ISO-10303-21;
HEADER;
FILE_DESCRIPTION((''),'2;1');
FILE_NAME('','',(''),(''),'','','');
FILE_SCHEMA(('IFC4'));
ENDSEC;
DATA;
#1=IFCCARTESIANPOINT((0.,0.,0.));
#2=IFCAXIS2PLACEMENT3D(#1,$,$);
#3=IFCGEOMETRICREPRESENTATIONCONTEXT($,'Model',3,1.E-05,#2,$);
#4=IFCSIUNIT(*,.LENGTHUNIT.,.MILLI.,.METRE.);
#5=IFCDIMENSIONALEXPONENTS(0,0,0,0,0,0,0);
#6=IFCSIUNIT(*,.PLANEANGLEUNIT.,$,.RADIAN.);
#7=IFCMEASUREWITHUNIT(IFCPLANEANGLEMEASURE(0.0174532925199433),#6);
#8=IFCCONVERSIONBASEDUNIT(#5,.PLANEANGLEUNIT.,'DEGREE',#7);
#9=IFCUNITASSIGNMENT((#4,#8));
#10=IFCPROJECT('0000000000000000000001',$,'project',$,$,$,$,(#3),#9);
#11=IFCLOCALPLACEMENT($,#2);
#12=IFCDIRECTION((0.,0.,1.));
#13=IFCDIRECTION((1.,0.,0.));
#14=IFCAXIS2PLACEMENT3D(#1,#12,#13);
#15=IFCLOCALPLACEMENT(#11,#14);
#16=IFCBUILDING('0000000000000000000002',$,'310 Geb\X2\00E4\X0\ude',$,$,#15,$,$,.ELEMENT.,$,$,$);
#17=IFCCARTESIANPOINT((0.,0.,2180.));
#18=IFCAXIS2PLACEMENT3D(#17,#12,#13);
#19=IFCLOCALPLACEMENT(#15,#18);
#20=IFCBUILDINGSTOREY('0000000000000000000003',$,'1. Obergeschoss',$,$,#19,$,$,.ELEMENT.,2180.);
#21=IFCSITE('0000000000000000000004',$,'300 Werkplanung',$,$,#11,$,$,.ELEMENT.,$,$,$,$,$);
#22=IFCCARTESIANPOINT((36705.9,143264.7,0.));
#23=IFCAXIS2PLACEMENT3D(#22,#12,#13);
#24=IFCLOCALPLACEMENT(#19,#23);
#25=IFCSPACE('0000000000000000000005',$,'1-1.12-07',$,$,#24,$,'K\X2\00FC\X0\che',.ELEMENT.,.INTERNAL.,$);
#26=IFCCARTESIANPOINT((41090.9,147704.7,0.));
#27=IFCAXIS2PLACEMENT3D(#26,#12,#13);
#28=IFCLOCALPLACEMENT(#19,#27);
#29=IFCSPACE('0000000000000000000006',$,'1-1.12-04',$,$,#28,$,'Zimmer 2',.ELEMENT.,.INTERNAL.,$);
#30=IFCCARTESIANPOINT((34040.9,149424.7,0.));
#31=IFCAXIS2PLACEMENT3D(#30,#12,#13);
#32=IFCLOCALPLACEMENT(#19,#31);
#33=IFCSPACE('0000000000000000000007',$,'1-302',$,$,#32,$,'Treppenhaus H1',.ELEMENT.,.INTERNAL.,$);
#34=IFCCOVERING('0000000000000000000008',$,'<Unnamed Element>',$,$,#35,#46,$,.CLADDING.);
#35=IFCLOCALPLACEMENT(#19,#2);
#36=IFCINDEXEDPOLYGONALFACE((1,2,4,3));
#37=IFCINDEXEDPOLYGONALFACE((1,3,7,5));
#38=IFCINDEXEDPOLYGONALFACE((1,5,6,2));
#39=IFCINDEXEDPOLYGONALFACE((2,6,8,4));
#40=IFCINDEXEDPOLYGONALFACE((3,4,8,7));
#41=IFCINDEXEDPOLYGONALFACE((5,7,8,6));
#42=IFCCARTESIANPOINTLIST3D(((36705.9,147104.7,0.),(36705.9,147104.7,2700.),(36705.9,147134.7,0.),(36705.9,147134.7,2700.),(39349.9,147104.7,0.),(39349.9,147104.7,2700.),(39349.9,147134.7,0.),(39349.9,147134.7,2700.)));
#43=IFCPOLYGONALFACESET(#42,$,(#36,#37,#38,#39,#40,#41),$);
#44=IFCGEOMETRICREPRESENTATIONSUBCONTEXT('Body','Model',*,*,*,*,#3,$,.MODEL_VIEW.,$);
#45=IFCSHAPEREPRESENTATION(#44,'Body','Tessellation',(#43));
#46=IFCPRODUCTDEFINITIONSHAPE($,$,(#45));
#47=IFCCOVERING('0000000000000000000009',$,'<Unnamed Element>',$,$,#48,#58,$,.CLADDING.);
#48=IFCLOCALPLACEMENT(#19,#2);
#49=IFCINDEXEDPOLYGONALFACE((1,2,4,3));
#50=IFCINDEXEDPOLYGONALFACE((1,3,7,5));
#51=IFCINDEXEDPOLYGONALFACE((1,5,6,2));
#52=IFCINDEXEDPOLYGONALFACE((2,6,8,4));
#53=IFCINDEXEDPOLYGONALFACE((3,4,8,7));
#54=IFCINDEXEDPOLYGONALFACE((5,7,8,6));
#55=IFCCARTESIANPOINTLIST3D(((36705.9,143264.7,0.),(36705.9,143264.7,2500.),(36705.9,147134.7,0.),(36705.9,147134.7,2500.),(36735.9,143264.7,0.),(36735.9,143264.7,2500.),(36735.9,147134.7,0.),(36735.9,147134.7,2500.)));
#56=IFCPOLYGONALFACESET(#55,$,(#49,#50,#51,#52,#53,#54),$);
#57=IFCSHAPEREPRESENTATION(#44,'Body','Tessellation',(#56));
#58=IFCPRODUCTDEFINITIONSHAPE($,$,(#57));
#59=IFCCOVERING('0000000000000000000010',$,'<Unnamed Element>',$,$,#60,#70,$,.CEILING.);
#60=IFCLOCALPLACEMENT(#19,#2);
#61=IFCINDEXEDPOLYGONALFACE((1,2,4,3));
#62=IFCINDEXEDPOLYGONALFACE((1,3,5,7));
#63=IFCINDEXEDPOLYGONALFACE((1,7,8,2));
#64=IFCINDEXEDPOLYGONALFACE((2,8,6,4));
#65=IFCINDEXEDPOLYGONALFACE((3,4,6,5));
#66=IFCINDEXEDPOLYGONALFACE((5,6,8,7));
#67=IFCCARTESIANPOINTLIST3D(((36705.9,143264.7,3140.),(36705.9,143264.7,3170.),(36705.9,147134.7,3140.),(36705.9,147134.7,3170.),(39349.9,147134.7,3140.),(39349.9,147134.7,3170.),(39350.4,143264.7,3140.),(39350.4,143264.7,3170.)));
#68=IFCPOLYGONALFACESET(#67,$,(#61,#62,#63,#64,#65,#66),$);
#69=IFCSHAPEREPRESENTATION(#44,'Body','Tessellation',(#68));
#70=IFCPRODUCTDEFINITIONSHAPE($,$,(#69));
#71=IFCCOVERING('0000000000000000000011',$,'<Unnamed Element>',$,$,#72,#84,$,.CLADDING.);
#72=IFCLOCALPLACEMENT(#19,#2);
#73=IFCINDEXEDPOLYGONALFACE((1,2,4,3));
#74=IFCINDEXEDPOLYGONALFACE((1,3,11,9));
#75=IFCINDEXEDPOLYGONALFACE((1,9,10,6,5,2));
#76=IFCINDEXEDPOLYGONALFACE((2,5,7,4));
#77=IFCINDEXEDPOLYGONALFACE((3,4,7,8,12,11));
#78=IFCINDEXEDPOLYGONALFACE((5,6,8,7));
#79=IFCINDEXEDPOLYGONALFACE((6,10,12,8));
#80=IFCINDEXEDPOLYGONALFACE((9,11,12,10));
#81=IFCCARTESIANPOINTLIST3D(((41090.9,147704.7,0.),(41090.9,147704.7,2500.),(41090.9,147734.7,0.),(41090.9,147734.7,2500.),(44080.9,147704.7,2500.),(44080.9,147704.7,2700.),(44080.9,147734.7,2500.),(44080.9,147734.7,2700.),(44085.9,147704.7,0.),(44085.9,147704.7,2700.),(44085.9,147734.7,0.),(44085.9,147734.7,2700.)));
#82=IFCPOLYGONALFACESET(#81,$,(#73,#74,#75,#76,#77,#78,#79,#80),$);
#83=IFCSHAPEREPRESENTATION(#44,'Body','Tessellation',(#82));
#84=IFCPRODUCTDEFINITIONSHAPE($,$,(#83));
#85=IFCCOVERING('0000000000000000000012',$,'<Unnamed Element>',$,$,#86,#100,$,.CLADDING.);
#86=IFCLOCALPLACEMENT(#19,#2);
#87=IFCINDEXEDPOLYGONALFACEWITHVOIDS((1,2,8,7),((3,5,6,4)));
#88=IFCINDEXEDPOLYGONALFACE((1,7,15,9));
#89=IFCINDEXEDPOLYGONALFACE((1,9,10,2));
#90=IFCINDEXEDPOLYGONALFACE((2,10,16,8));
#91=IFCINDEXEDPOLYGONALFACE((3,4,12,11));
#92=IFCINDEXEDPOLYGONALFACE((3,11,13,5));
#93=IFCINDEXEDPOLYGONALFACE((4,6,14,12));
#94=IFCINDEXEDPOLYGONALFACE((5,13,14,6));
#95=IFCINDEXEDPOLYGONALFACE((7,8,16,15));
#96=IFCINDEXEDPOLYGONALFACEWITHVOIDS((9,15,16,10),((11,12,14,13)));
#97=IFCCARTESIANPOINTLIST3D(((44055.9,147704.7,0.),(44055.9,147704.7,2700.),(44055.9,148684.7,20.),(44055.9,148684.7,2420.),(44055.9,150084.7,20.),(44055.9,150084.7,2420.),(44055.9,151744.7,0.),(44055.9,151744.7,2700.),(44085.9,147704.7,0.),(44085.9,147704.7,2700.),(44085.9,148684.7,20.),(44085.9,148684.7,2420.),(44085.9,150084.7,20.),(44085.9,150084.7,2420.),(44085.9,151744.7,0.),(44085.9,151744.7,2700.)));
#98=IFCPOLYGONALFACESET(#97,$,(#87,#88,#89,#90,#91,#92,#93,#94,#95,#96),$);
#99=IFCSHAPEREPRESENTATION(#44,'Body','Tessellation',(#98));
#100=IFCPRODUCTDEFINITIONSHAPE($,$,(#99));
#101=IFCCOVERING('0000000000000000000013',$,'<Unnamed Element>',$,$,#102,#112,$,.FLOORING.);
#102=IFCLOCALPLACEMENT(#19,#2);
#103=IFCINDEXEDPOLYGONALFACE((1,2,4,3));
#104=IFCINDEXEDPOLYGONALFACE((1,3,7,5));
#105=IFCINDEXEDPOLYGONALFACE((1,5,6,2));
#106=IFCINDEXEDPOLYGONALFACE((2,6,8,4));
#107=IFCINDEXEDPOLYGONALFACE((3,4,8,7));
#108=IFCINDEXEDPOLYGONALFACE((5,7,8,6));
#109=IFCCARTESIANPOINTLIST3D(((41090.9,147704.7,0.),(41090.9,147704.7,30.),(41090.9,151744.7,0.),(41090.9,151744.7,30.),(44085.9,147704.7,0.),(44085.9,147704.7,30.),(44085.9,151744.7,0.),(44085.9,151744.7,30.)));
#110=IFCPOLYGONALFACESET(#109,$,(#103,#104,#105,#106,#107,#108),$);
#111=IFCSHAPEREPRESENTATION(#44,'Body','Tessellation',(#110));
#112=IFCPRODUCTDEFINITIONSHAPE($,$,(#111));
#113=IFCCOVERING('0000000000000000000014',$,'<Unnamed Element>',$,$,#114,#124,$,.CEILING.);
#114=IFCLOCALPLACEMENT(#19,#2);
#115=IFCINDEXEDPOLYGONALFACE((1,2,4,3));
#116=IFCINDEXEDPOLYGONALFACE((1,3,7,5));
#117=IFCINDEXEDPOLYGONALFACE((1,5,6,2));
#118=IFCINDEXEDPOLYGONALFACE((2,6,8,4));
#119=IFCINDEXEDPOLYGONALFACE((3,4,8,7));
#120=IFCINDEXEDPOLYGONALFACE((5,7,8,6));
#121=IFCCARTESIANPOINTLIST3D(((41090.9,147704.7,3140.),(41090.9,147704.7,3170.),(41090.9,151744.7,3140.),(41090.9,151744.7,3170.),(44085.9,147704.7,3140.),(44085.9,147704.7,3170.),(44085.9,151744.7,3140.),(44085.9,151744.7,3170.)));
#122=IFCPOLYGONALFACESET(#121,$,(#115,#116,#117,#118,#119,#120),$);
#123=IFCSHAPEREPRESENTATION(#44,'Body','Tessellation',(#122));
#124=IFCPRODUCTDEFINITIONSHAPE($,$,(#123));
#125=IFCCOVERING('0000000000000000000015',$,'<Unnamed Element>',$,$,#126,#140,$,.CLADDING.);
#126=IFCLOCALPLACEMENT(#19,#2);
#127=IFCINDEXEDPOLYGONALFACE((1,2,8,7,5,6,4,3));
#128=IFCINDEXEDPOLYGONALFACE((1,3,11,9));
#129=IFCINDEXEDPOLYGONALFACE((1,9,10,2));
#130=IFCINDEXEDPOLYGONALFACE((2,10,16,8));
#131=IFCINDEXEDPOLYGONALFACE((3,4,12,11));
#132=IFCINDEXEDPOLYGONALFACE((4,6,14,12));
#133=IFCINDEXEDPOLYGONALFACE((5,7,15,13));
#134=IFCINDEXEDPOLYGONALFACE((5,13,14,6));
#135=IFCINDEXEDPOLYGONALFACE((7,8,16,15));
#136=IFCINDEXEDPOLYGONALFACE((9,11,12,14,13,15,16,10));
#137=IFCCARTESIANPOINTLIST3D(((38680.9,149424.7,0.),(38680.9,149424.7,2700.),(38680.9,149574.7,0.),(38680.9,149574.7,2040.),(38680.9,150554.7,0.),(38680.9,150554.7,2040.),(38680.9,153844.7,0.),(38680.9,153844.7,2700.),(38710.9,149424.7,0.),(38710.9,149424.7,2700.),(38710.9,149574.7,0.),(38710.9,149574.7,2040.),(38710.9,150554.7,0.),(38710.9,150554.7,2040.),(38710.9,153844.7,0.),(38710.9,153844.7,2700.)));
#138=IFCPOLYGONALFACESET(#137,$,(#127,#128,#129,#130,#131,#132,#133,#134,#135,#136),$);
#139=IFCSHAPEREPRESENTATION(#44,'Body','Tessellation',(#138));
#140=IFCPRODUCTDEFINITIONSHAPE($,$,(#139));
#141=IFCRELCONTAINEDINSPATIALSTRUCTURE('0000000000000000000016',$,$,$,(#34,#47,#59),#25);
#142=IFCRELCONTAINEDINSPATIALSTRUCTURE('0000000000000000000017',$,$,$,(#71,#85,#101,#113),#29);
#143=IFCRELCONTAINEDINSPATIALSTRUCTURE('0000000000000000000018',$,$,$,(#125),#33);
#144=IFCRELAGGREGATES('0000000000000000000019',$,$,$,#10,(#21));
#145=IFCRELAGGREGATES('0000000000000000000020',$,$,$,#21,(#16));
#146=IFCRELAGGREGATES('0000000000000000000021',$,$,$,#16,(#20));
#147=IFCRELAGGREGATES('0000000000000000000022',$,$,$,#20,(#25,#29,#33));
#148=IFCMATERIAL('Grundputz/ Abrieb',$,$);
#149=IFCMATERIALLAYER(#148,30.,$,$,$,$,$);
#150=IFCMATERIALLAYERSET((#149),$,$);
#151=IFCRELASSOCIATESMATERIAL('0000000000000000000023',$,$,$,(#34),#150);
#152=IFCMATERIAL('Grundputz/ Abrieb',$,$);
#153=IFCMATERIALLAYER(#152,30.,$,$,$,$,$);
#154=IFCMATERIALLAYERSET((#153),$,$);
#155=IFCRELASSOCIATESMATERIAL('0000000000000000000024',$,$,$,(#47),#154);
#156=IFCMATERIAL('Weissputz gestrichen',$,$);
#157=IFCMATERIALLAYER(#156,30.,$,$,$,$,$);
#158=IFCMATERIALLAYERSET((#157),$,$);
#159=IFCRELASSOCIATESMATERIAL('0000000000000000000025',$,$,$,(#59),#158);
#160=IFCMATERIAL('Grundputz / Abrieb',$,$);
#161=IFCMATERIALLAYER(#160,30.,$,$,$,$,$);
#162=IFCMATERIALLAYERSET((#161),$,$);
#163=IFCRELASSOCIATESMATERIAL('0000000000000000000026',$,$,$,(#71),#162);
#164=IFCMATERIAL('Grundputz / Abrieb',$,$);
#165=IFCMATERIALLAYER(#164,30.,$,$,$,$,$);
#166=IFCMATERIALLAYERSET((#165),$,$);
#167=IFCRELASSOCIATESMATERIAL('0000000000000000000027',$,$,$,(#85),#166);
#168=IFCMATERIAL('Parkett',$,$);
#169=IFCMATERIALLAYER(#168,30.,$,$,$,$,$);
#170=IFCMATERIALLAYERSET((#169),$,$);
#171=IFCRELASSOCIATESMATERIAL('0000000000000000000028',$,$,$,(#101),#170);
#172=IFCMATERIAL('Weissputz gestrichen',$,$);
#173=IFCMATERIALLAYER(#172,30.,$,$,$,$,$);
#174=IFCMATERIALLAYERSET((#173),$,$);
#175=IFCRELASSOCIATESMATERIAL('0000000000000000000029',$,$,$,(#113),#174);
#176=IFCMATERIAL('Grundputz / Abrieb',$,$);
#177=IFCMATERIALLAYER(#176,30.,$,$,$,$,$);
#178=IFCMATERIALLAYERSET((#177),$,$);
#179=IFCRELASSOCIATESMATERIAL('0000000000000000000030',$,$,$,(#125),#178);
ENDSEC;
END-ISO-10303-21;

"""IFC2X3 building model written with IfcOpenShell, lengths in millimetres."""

from ifc_helpers import new_model, entity, si_unit, converted_unit, frame, frame_2d, origin, origin_with_axes, place, context, subcontext, project, spatial, polyline, rectangle, outline, extrude, material, layer, layer_set, layer_usage, element, save


model = new_model("IFC2X3")

# Units and contexts
model_context = context("Model", 3, precision=1e-05, world=origin())
body_context = subcontext(model_context, "Body", "Model", "MODEL_VIEW")
ifc_project = project(units=[si_unit("LENGTHUNIT", "METRE", prefix="MILLI"), converted_unit("PLANEANGLEUNIT", "DEGREE", entity("IfcPlaneAngleMeasure", 0.0174532925199433), si_unit("PLANEANGLEUNIT", "RADIAN"), dimensions=[0, 0, 0, 0, 0, 0, 0])], contexts=[model_context])

# Site, building, storey
site_placement = place(None, origin())
site = spatial("IfcSite", under=ifc_project, at=site_placement, Name="300 Werkplanung", CompositionType="ELEMENT")
building_placement = place(site_placement, origin_with_axes())
building = spatial("IfcBuilding", under=site, at=building_placement, Name="310 Gebäude", CompositionType="ELEMENT")
storey_placement = place(building_placement, frame((0.0, 0.0, 2180.0), z_axis=(0.0, 0.0, 1.0), x_axis=(1.0, 0.0, 0.0)))
storey = spatial("IfcBuildingStorey", under=building, at=storey_placement, Name="1. Obergeschoss", CompositionType="ELEMENT", Elevation=2180.0)

# Shared definitions
space_1_placement = place(storey_placement, frame((36705.9, 143264.7, 0.0), z_axis=(0.0, 0.0, 1.0), x_axis=(1.0, 0.0, 0.0)))
space_1 = spatial("IfcSpace", under=storey, at=space_1_placement, Name="1-1.12-07", LongName="Küche", CompositionType="ELEMENT", InteriorOrExteriorSpace="INTERNAL")

# Coverings
ifc_material_1 = material(Name="Grundputz/ Abrieb")
ifc_layer_1 = layer(ifc_material_1, 30.0)
ifc_layer_set_1 = layer_set([ifc_layer_1])
ifc_layer_usage_1 = layer_usage(ifc_layer_set_1, "AXIS3", "POSITIVE", 0.0)
covering_1_placement = place(space_1_placement, frame((2644.0, 3870.0, 0.0), z_axis=(0.0, 0.0, 1.0), x_axis=(-1.0, 0.0, 0.0)))
element("IfcCovering", 1, at=covering_1_placement, inside=space_1, material=ifc_layer_usage_1, Name="<Unnamed Element>", PredefinedType="CLADDING", context=body_context, shape_type="SweptSolid", body=[
    extrude(rectangle(XDim=2700.0, YDim=2644.0, at=frame_2d((-1322.0, 1350.0), x_axis=(0.0, 1.0))), frame((2644.0, 0.0, 2700.0), z_axis=(0.0, 1.0, 0.0), x_axis=(1.0, 0.0, 0.0)), (0.0, 0.0, 1.0), 30.0),
])
ifc_material_2 = material(Name="Grundputz/ Abrieb")
ifc_layer_2 = layer(ifc_material_2, 30.0)
ifc_layer_set_2 = layer_set([ifc_layer_2])
ifc_layer_usage_2 = layer_usage(ifc_layer_set_2, "AXIS3", "POSITIVE", 0.0)
covering_2_placement = place(space_1_placement, frame((0.0, 3870.0, 0.0), z_axis=(0.0, 0.0, 1.0), x_axis=(0.0, -1.0, 0.0)))
element("IfcCovering", 2, at=covering_2_placement, inside=space_1, material=ifc_layer_usage_2, Name="<Unnamed Element>", PredefinedType="CLADDING", context=body_context, shape_type="SweptSolid", body=[
    extrude(rectangle(XDim=2500.0, YDim=3870.0, at=frame_2d((-1935.0, 1250.0), x_axis=(0.0, 1.0))), frame((3870.0, 0.0, 2500.0), z_axis=(0.0, 1.0, 0.0), x_axis=(1.0, 0.0, 0.0)), (0.0, 0.0, 1.0), 30.0),
])
ifc_material_3 = material(Name="Weissputz gestrichen")
ifc_layer_3 = layer(ifc_material_3, 30.0)
ifc_layer_set_3 = layer_set([ifc_layer_3])
ifc_layer_usage_3 = layer_usage(ifc_layer_set_3, "AXIS3", "POSITIVE", 0.0)
covering_3_placement = place(space_1_placement, frame((1322.1, 1935.0, 3170.0), z_axis=(0.0, 0.0, -1.0), x_axis=(1.0, 0.0, 0.0)))
element("IfcCovering", 3, at=covering_3_placement, inside=space_1, material=ifc_layer_usage_3, Name="<Unnamed Element>", PredefinedType="CEILING", context=body_context, shape_type="SweptSolid", body=[
    extrude(outline(polyline([(-1322.1, -1935.0), (1321.9, -1935.0), (1322.4, 1935.0), (-1322.1, 1935.0), (-1322.1, -1935.0)])), origin_with_axes(), (0.0, 0.0, 1.0), 30.0),
])

# Shared definitions
space_2_placement = place(storey_placement, frame((41090.9, 147704.7, 0.0), z_axis=(0.0, 0.0, 1.0), x_axis=(1.0, 0.0, 0.0)))
space_2 = spatial("IfcSpace", under=storey, at=space_2_placement, Name="1-1.12-04", LongName="Zimmer 2", CompositionType="ELEMENT", InteriorOrExteriorSpace="INTERNAL")

# Coverings
ifc_material_4 = material(Name="Grundputz / Abrieb")
ifc_layer_4 = layer(ifc_material_4, 30.0)
ifc_layer_set_4 = layer_set([ifc_layer_4])
ifc_layer_usage_4 = layer_usage(ifc_layer_set_4, "AXIS3", "POSITIVE", 0.0)
covering_4_placement = place(space_2_placement, frame((0.0, 0.0, 0.0), z_axis=(0.0, 0.0, 1.0), x_axis=(1.0, 0.0, 0.0)))
element("IfcCovering", 4, at=covering_4_placement, inside=space_2, material=ifc_layer_usage_4, Name="<Unnamed Element>", PredefinedType="CLADDING", context=body_context, shape_type="SweptSolid", body=[
    extrude(outline(polyline([(2995.0, 0.0), (2995.0, -2700.0), (2990.0, -2700.0), (2990.0, -2500.0), (0.0, -2500.0), (0.0, 0.0), (2995.0, 0.0)])), frame((0.0, 0.0, 0.0), z_axis=(0.0, 1.0, 0.0), x_axis=(1.0, 0.0, 0.0)), (0.0, 0.0, 1.0), 30.0),
])
ifc_material_5 = material(Name="Grundputz / Abrieb")
ifc_layer_5 = layer(ifc_material_5, 30.0)
ifc_layer_set_5 = layer_set([ifc_layer_5])
ifc_layer_usage_5 = layer_usage(ifc_layer_set_5, "AXIS3", "POSITIVE", 0.0)
covering_5_placement = place(space_2_placement, frame((2995.0, 0.0, 0.0), z_axis=(0.0, 0.0, 1.0), x_axis=(0.0, 1.0, 0.0)))
element("IfcCovering", 5, at=covering_5_placement, inside=space_2, material=ifc_layer_usage_5, Name="<Unnamed Element>", PredefinedType="CLADDING", context=body_context, shape_type="SweptSolid", body=[
    extrude(outline(polyline([(4040.0, 0.0), (4040.0, -2700.0), (0.0, -2700.0), (0.0, 0.0), (4040.0, 0.0)]), holes=[polyline([(2380.0, -20.0), (980.0, -20.0), (980.0, -2420.0), (2380.0, -2420.0), (2380.0, -20.0)])]), frame((0.0, 0.0, 0.0), z_axis=(0.0, 1.0, 0.0), x_axis=(1.0, 0.0, 0.0)), (0.0, 0.0, 1.0), 30.0),
])
ifc_material_6 = material(Name="Parkett")
ifc_layer_6 = layer(ifc_material_6, 30.0)
ifc_layer_set_6 = layer_set([ifc_layer_6])
ifc_layer_usage_6 = layer_usage(ifc_layer_set_6, "AXIS3", "POSITIVE", 0.0)
covering_6_placement = place(space_2_placement, origin_with_axes())
element("IfcCovering", 6, at=covering_6_placement, inside=space_2, material=ifc_layer_usage_6, Name="<Unnamed Element>", PredefinedType="FLOORING", context=body_context, shape_type="SweptSolid", body=[
    extrude(rectangle(XDim=2995.0, YDim=4040.0, at=frame_2d((-1497.5, -2020.0), x_axis=(-1.0, 0.0))), frame((2995.0, 4040.0, 0.0), z_axis=(0.0, 0.0, 1.0), x_axis=(1.0, 0.0, 0.0)), (0.0, 0.0, 1.0), 30.0),
])
ifc_material_7 = material(Name="Weissputz gestrichen")
ifc_layer_7 = layer(ifc_material_7, 30.0)
ifc_layer_set_7 = layer_set([ifc_layer_7])
ifc_layer_usage_7 = layer_usage(ifc_layer_set_7, "AXIS3", "POSITIVE", 0.0)
covering_7_placement = place(space_2_placement, frame((1497.5, 2020.0, 3170.0), z_axis=(0.0, 0.0, -1.0), x_axis=(1.0, 0.0, 0.0)))
element("IfcCovering", 7, at=covering_7_placement, inside=space_2, material=ifc_layer_usage_7, Name="<Unnamed Element>", PredefinedType="CEILING", context=body_context, shape_type="SweptSolid", body=[
    extrude(rectangle(XDim=2995.0, YDim=4040.0, at=frame_2d((1497.5, 2020.0), x_axis=(1.0, 0.0))), frame((-1497.5, -2020.0, 0.0), z_axis=(0.0, 0.0, 1.0), x_axis=(1.0, 0.0, 0.0)), (0.0, 0.0, 1.0), 30.0),
])

# Shared definitions
space_3_placement = place(storey_placement, frame((34040.9, 149424.7, 0.0), z_axis=(0.0, 0.0, 1.0), x_axis=(1.0, 0.0, 0.0)))
space_3 = spatial("IfcSpace", under=storey, at=space_3_placement, Name="1-302", LongName="Treppenhaus H1", CompositionType="ELEMENT", InteriorOrExteriorSpace="INTERNAL")

# Covering
ifc_material_8 = material(Name="Grundputz / Abrieb")
ifc_layer_8 = layer(ifc_material_8, 30.0)
ifc_layer_set_8 = layer_set([ifc_layer_8])
ifc_layer_usage_8 = layer_usage(ifc_layer_set_8, "AXIS3", "POSITIVE", 0.0)
covering_8_placement = place(space_3_placement, frame((4670.0, 0.0, 0.0), z_axis=(0.0, 0.0, 1.0), x_axis=(0.0, 1.0, 0.0)))
element("IfcCovering", 8, at=covering_8_placement, inside=space_3, material=ifc_layer_usage_8, Name="<Unnamed Element>", PredefinedType="CLADDING", context=body_context, shape_type="SweptSolid", body=[
    extrude(outline(polyline([(4420.0, 0.0), (4420.0, -2700.0), (0.0, -2700.0), (0.0, 0.0), (150.0, 0.0), (150.0, -2040.0), (1130.0, -2040.0), (1130.0, 0.0), (4420.0, 0.0)])), frame((0.0, 0.0, 0.0), z_axis=(0.0, 1.0, 0.0), x_axis=(1.0, 0.0, 0.0)), (0.0, 0.0, 1.0), 30.0),
])

save(model, "model.ifc")
